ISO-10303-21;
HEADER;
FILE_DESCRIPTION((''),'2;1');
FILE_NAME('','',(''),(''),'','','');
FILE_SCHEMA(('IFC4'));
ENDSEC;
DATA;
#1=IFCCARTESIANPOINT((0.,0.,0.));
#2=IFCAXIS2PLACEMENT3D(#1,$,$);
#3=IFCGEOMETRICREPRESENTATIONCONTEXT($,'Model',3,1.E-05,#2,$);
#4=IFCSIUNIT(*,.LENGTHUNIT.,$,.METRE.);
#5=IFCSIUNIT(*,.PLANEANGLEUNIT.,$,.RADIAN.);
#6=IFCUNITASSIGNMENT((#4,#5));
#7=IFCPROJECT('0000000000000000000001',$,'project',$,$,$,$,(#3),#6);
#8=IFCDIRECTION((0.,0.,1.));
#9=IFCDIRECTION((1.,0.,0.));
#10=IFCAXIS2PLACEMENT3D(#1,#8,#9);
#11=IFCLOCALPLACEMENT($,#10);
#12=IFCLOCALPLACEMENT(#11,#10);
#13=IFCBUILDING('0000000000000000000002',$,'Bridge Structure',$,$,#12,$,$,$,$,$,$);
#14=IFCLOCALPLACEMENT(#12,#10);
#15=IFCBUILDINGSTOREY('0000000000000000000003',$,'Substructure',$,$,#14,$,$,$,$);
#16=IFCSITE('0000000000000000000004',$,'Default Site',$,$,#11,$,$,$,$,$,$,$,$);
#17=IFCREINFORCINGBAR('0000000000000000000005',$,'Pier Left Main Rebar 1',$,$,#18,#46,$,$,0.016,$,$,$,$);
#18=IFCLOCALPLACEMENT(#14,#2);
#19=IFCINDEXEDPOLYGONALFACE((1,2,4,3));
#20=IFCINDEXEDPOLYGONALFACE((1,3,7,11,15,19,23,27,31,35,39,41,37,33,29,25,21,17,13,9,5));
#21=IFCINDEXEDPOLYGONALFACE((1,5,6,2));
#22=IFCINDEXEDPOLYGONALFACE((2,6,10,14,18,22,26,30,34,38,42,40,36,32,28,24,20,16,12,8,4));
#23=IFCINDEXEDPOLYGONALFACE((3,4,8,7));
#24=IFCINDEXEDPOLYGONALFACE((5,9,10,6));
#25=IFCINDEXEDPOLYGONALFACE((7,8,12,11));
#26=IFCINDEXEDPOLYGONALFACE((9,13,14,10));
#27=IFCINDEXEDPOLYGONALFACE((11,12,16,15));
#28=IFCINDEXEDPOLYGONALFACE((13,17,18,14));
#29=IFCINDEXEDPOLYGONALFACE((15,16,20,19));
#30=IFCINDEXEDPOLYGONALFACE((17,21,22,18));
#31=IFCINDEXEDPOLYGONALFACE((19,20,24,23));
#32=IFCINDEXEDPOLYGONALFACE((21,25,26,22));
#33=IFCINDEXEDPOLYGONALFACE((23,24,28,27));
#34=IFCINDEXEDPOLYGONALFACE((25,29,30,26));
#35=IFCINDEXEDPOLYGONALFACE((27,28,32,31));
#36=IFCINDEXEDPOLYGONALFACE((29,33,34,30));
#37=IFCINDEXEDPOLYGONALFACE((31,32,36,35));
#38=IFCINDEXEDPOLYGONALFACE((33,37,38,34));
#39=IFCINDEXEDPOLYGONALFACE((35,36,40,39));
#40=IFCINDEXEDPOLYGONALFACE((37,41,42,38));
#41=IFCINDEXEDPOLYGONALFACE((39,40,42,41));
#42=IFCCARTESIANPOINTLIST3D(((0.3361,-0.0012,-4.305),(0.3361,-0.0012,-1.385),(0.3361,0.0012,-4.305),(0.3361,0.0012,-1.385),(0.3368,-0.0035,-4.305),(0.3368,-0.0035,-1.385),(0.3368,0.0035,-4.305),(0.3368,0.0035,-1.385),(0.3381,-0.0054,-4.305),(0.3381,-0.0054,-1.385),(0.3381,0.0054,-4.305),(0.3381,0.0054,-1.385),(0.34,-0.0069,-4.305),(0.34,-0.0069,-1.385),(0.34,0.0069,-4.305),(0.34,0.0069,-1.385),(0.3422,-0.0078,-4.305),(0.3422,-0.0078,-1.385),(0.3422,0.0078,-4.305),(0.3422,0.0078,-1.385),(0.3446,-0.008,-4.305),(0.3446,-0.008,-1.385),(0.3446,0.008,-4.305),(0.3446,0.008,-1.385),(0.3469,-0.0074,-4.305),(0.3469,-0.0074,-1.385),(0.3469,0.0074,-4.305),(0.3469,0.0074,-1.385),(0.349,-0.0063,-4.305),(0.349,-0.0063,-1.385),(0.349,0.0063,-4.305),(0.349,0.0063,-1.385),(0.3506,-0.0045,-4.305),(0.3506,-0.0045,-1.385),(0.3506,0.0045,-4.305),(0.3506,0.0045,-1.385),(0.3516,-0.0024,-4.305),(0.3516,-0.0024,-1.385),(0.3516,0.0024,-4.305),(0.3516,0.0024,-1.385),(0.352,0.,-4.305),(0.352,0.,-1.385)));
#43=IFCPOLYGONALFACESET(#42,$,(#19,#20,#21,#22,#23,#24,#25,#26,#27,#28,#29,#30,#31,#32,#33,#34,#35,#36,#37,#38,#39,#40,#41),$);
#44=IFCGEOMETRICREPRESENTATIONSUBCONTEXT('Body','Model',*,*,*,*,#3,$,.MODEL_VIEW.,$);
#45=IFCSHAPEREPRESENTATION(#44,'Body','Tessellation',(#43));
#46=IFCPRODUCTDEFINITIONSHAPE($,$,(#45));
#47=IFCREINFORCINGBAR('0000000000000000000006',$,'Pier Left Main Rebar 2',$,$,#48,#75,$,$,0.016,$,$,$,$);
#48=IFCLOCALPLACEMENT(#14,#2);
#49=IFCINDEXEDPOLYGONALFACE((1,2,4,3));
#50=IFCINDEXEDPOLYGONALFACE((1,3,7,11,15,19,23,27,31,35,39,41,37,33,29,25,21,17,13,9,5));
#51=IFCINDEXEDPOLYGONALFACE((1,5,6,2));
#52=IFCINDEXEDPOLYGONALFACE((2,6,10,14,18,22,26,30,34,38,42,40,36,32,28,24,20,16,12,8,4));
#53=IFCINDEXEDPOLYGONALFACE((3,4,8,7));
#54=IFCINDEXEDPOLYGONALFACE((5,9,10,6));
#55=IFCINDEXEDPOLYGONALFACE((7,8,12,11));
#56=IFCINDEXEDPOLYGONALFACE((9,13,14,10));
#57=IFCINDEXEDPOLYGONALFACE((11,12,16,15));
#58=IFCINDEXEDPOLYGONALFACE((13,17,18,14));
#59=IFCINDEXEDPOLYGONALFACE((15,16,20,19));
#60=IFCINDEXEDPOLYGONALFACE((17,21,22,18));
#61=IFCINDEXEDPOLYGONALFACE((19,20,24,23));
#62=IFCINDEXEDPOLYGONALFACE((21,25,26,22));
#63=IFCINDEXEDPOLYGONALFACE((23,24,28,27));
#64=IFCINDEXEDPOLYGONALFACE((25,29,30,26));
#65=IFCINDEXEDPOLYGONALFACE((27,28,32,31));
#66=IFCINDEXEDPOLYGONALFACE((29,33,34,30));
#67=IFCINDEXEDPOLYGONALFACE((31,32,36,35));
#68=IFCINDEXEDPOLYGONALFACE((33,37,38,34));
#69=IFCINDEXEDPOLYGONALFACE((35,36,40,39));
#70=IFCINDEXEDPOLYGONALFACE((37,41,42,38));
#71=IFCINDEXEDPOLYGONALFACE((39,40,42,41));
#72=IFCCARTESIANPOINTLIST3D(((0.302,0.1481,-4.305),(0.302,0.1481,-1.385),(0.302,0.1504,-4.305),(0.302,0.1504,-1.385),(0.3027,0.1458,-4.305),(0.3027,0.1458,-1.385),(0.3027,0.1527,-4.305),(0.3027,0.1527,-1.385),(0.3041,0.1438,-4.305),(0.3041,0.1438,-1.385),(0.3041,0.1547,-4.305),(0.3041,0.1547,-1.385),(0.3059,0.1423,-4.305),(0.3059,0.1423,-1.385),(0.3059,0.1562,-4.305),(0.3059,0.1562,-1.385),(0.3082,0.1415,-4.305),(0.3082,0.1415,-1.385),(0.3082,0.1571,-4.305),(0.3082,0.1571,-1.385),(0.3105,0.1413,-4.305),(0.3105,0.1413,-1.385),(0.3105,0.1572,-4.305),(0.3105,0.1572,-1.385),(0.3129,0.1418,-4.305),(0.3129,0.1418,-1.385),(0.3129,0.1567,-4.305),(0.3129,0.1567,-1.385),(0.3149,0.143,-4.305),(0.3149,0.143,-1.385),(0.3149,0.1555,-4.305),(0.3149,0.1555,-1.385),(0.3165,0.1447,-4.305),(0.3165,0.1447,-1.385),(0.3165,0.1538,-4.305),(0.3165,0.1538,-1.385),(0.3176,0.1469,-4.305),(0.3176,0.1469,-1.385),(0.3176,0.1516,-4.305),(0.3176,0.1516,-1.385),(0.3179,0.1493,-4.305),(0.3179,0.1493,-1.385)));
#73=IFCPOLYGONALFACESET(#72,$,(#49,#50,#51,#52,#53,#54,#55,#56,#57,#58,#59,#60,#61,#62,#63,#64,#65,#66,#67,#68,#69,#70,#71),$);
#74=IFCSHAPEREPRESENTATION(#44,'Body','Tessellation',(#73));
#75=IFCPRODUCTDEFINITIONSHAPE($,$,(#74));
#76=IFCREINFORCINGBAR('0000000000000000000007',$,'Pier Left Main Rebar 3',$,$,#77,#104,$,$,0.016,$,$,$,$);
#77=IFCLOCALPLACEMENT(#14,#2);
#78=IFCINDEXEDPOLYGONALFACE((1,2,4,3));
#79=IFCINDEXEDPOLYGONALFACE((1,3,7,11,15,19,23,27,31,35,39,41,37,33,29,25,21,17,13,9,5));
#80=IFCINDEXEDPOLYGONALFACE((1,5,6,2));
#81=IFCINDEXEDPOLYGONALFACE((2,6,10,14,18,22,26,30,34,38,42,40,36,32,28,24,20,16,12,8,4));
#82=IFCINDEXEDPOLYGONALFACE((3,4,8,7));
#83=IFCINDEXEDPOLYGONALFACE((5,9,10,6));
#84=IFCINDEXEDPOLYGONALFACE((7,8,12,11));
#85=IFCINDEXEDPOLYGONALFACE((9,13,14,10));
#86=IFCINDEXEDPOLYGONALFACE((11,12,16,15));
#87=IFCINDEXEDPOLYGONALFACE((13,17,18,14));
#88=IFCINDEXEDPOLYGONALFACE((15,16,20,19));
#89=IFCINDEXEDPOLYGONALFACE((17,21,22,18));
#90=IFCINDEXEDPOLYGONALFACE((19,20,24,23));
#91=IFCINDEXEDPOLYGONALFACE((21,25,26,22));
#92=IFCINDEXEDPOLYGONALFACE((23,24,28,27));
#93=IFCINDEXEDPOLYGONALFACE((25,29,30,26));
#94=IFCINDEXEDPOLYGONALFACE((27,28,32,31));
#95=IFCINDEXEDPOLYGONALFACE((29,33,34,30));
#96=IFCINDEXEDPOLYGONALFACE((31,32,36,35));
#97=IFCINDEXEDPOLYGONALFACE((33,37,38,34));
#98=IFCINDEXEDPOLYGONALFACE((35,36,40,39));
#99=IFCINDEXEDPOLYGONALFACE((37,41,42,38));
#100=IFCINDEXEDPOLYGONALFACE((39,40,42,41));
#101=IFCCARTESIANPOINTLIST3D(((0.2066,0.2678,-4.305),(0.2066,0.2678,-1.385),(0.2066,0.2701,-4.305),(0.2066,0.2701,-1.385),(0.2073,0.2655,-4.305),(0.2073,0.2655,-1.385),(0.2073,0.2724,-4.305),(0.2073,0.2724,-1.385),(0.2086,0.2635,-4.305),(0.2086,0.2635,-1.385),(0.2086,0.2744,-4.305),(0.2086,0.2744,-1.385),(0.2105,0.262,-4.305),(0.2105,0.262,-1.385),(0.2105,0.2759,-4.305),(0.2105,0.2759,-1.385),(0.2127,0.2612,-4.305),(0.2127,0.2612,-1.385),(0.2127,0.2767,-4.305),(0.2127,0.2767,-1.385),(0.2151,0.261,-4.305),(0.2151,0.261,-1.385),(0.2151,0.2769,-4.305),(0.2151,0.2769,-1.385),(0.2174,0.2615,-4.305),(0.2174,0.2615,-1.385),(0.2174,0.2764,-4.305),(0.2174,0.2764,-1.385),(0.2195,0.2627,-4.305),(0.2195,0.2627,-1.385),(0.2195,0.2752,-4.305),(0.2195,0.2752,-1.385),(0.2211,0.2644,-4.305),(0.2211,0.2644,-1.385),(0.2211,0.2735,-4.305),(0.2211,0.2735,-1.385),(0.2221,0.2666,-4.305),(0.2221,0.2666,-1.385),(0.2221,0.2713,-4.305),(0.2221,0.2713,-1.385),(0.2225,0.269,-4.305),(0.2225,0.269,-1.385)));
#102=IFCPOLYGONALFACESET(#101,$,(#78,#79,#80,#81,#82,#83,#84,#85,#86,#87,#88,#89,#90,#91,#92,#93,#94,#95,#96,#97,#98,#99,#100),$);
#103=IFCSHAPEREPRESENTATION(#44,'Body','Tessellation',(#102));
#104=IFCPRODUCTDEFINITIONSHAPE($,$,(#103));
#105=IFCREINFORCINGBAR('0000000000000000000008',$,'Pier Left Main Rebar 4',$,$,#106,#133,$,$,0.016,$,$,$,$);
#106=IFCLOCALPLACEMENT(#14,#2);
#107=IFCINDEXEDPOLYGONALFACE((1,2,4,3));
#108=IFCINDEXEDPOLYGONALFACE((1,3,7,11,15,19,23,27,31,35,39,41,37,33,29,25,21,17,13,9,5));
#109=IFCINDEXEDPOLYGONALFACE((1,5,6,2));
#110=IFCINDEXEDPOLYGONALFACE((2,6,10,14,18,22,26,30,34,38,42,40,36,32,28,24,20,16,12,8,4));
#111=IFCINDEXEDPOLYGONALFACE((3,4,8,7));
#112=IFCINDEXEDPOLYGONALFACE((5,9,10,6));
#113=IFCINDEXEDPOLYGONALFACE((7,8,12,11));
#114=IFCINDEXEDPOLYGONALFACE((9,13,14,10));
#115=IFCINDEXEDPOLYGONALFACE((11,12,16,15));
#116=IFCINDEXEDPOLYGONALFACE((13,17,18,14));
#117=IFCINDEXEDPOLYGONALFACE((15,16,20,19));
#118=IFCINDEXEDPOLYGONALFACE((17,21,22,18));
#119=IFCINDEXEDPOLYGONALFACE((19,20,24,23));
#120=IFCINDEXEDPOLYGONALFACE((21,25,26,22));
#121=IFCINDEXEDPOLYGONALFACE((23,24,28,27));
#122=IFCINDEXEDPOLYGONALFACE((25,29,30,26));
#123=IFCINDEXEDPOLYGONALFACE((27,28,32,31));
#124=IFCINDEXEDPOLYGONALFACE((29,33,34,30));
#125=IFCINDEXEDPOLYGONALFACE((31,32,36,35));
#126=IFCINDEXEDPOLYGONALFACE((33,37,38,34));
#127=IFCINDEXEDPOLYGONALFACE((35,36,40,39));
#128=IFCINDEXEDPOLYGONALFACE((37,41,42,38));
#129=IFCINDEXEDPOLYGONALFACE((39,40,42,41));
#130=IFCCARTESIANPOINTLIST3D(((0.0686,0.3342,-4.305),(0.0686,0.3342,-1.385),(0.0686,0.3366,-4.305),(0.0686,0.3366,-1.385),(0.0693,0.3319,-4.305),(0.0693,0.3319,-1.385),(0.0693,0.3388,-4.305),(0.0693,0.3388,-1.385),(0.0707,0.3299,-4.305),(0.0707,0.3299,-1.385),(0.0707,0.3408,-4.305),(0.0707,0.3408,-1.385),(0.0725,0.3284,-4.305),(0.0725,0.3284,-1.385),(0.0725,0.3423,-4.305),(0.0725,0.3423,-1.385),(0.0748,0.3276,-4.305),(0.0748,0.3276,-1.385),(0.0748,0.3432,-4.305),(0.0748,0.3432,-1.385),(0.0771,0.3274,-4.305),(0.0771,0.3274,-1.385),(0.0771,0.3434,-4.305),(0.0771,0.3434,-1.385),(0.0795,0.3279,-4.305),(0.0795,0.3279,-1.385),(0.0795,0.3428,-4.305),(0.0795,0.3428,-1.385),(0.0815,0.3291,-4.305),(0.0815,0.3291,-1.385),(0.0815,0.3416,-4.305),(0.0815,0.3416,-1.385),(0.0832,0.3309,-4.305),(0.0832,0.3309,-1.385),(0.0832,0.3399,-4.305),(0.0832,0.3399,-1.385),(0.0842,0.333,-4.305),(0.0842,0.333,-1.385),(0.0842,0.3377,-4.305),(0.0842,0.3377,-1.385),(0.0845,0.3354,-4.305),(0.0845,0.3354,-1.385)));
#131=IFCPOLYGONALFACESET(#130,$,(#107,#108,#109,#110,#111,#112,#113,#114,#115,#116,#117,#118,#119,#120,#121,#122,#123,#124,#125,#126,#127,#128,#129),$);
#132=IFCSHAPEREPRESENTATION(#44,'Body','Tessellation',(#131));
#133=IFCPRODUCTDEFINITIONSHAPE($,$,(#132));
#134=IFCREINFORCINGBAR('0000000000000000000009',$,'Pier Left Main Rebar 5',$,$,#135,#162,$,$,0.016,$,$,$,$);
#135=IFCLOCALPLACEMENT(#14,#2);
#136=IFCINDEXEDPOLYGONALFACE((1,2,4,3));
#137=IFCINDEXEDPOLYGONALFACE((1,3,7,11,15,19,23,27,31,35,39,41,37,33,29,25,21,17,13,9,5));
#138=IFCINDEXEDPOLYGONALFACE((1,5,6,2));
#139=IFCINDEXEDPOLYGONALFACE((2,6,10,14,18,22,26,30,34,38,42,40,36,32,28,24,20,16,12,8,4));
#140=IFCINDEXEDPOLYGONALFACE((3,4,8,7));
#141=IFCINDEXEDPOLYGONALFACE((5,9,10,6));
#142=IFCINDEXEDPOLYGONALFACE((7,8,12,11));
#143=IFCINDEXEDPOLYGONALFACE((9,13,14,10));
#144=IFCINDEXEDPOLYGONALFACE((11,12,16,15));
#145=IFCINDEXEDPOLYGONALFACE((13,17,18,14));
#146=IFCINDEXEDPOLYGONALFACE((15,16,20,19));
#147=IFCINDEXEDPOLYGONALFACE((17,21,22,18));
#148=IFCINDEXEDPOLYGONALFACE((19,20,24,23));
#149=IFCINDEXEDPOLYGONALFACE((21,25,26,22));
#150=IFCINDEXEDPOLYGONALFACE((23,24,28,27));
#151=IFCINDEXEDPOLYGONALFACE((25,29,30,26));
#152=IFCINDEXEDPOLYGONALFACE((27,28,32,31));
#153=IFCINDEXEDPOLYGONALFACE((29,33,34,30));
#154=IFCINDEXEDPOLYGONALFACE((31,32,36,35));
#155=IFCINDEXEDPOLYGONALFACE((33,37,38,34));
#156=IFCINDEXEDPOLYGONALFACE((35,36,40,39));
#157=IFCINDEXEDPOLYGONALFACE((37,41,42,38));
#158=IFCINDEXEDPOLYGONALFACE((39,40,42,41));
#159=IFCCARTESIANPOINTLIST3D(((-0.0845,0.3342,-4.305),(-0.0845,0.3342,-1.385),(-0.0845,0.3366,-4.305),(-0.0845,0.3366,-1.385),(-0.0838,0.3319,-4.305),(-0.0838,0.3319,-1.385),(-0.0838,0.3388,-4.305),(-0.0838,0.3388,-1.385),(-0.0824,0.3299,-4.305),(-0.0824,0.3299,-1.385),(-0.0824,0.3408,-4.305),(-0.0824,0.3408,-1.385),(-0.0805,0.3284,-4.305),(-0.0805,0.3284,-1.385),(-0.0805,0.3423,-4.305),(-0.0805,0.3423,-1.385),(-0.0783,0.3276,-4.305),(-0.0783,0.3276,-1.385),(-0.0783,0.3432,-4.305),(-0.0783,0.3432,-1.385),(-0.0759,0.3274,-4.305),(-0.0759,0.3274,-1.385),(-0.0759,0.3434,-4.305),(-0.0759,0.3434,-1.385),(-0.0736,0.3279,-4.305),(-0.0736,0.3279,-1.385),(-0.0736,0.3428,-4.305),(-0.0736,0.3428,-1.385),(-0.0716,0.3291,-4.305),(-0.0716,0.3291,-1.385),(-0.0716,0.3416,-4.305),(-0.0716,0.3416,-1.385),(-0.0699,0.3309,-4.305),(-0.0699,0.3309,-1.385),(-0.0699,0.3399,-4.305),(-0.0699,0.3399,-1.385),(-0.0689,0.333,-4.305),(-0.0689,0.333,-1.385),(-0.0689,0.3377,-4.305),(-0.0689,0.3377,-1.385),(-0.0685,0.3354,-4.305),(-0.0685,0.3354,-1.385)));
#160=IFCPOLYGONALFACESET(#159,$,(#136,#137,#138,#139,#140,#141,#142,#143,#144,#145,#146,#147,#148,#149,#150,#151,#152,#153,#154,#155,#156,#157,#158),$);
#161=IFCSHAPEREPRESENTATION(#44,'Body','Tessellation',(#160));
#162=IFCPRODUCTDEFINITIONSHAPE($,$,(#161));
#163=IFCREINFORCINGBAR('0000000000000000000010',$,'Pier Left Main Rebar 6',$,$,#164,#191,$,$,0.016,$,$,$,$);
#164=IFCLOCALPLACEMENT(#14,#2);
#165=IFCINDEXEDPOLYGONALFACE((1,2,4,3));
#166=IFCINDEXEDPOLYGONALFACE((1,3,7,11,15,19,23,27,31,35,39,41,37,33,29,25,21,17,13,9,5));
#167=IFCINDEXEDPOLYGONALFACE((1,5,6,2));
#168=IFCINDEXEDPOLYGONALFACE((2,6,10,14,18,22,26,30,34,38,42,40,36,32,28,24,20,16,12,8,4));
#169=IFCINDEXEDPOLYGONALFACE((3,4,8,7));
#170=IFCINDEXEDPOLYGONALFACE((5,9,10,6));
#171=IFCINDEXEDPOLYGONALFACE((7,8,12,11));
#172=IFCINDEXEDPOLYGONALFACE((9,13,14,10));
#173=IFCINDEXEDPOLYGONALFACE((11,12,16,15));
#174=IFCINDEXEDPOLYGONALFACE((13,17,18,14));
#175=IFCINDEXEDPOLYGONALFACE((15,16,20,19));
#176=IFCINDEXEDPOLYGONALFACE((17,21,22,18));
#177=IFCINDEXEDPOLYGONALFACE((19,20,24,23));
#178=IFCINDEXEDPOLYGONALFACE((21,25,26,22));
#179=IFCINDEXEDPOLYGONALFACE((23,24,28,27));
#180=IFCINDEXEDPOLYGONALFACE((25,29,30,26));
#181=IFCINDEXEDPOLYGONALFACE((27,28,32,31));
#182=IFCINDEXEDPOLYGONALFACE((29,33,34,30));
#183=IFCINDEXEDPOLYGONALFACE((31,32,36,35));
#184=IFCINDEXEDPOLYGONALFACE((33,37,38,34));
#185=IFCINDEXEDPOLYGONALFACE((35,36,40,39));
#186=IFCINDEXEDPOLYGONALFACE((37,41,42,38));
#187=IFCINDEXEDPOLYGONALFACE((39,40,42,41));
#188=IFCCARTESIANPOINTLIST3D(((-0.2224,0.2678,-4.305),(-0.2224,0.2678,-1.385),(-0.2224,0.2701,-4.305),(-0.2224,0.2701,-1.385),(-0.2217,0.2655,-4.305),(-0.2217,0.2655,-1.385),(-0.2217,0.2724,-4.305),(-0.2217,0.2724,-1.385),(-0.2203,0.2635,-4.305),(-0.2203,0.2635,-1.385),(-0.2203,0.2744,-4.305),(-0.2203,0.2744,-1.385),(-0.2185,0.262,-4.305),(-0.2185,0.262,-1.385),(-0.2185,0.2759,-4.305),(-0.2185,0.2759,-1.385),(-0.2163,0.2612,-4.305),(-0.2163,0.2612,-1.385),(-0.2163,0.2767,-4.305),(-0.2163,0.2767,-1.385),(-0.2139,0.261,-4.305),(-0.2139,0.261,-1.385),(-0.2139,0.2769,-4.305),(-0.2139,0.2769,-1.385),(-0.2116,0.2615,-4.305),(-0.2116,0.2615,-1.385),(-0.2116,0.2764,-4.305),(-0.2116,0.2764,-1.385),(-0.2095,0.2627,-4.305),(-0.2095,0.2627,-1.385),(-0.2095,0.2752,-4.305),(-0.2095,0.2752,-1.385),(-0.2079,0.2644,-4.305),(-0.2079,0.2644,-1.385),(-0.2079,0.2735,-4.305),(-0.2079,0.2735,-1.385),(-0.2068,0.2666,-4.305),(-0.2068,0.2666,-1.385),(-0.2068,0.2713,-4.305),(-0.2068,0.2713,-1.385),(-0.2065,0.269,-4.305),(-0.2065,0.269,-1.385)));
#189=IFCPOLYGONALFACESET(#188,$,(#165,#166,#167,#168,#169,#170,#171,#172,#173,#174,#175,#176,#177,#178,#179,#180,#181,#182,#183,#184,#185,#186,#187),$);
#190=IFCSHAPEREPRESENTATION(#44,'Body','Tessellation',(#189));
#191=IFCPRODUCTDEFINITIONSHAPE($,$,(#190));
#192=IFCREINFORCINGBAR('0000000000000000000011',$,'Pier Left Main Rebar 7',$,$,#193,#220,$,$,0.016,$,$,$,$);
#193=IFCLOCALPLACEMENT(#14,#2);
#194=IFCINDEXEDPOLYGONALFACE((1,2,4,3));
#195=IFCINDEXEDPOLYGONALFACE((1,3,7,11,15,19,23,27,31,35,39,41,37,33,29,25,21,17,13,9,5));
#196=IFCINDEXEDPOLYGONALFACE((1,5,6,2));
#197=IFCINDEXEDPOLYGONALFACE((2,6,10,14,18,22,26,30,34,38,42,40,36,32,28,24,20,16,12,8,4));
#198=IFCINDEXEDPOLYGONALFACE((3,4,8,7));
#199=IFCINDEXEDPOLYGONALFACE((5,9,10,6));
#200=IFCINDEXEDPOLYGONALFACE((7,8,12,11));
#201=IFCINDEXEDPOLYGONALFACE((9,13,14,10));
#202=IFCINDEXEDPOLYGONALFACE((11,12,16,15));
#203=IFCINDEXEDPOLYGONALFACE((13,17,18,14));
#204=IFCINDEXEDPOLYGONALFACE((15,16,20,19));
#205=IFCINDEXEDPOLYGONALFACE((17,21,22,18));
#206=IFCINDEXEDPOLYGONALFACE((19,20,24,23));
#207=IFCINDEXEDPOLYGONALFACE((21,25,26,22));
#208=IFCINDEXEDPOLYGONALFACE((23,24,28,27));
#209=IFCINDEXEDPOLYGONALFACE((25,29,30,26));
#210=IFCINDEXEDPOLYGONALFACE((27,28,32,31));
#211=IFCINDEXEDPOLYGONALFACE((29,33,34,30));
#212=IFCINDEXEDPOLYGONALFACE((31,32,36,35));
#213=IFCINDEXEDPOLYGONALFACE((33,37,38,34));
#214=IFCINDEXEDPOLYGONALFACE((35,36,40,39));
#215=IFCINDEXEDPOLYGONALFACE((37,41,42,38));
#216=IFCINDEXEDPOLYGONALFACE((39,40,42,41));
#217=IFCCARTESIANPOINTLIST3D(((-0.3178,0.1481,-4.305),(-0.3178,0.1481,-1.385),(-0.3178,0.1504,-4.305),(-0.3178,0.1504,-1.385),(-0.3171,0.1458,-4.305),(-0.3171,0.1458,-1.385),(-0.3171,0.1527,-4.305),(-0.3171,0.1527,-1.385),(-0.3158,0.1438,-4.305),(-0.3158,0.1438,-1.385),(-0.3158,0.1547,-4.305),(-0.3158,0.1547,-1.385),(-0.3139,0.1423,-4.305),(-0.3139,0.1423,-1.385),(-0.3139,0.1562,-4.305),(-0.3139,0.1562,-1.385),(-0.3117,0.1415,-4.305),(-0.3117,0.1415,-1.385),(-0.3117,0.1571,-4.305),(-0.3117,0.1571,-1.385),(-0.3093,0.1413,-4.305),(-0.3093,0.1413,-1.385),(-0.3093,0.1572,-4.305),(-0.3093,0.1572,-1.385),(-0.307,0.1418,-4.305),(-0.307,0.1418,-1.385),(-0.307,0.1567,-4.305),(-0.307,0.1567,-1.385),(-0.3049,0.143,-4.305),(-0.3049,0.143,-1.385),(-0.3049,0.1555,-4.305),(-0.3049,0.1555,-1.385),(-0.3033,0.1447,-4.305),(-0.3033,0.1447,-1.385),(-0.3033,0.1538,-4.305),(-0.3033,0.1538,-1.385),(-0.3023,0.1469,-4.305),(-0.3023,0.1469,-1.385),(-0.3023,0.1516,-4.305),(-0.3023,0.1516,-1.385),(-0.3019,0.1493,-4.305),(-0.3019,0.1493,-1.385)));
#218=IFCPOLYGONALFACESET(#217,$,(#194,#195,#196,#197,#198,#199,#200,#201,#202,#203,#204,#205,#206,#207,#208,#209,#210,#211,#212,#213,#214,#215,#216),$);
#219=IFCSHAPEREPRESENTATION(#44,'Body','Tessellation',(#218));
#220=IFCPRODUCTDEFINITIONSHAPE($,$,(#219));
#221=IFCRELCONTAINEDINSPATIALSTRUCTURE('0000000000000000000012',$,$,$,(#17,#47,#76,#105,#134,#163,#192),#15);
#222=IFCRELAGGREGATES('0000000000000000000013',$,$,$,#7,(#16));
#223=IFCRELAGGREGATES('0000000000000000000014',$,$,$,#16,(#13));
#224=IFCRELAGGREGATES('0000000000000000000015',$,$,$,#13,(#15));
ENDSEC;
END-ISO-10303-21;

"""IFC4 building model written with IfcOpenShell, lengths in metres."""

from ifc_helpers import new_model, si_unit, frame, origin, origin_with_axes, origin_2d_with_axis, place, context, subcontext, project, spatial, circle, extrude, element, save


model = new_model("IFC4")

# Units and contexts
model_context = context("Model", 3, precision=1e-05, world=origin())
body_context = subcontext(model_context, "Body", "Model", "MODEL_VIEW")
ifc_project = project(units=[si_unit("LENGTHUNIT", "METRE"), si_unit("PLANEANGLEUNIT", "RADIAN")], contexts=[model_context])

# Site, building, storey
site_placement = place(None, origin_with_axes())
site = spatial("IfcSite", under=ifc_project, at=site_placement, Name="Default Site")
building_placement = place(site_placement, origin_with_axes())
building = spatial("IfcBuilding", under=site, at=building_placement, Name="Bridge Structure")
storey_placement = place(building_placement, origin_with_axes())
storey = spatial("IfcBuildingStorey", under=building, at=storey_placement, Name="Substructure")

# Reinforcing bars
for number, where, z_axis, x_axis, name in (
    (1, (0.344, 0.0, -4.305), (0.0, 0.0, 1.0), (1.0, 0.0, 0.0), "Pier Left Main Rebar 1"),
    (2, (0.3099, 0.1493, -4.305), (0.0, 0.0, 1.0), (1.0, 0.0, 0.0), "Pier Left Main Rebar 2"),
    (3, (0.2145, 0.269, -4.305), (0.0, 0.0, 1.0), (1.0, 0.0, 0.0), "Pier Left Main Rebar 3"),
    (4, (0.0765, 0.3354, -4.305), (0.0, 0.0, 1.0), (1.0, 0.0, 0.0), "Pier Left Main Rebar 4"),
    (5, (-0.0765, 0.3354, -4.305), (0.0, 0.0, 1.0), (1.0, 0.0, 0.0), "Pier Left Main Rebar 5"),
    (6, (-0.2145, 0.269, -4.305), (0.0, 0.0, 1.0), (1.0, 0.0, 0.0), "Pier Left Main Rebar 6"),
    (7, (-0.3099, 0.1493, -4.305), (0.0, 0.0, 1.0), (1.0, 0.0, 0.0), "Pier Left Main Rebar 7"),
):
    element("IfcReinforcingBar", number, at=place(storey_placement, frame(where, z_axis=z_axis, x_axis=x_axis)), inside=storey, Name=name, NominalDiameter=0.016, context=body_context, shape_type="SweptSolid", body=[
        extrude(circle(Radius=0.008, at=origin_2d_with_axis()), origin_with_axes(), (0.0, 0.0, 1.0), 2.92),
    ])

save(model, "model.ifc")
